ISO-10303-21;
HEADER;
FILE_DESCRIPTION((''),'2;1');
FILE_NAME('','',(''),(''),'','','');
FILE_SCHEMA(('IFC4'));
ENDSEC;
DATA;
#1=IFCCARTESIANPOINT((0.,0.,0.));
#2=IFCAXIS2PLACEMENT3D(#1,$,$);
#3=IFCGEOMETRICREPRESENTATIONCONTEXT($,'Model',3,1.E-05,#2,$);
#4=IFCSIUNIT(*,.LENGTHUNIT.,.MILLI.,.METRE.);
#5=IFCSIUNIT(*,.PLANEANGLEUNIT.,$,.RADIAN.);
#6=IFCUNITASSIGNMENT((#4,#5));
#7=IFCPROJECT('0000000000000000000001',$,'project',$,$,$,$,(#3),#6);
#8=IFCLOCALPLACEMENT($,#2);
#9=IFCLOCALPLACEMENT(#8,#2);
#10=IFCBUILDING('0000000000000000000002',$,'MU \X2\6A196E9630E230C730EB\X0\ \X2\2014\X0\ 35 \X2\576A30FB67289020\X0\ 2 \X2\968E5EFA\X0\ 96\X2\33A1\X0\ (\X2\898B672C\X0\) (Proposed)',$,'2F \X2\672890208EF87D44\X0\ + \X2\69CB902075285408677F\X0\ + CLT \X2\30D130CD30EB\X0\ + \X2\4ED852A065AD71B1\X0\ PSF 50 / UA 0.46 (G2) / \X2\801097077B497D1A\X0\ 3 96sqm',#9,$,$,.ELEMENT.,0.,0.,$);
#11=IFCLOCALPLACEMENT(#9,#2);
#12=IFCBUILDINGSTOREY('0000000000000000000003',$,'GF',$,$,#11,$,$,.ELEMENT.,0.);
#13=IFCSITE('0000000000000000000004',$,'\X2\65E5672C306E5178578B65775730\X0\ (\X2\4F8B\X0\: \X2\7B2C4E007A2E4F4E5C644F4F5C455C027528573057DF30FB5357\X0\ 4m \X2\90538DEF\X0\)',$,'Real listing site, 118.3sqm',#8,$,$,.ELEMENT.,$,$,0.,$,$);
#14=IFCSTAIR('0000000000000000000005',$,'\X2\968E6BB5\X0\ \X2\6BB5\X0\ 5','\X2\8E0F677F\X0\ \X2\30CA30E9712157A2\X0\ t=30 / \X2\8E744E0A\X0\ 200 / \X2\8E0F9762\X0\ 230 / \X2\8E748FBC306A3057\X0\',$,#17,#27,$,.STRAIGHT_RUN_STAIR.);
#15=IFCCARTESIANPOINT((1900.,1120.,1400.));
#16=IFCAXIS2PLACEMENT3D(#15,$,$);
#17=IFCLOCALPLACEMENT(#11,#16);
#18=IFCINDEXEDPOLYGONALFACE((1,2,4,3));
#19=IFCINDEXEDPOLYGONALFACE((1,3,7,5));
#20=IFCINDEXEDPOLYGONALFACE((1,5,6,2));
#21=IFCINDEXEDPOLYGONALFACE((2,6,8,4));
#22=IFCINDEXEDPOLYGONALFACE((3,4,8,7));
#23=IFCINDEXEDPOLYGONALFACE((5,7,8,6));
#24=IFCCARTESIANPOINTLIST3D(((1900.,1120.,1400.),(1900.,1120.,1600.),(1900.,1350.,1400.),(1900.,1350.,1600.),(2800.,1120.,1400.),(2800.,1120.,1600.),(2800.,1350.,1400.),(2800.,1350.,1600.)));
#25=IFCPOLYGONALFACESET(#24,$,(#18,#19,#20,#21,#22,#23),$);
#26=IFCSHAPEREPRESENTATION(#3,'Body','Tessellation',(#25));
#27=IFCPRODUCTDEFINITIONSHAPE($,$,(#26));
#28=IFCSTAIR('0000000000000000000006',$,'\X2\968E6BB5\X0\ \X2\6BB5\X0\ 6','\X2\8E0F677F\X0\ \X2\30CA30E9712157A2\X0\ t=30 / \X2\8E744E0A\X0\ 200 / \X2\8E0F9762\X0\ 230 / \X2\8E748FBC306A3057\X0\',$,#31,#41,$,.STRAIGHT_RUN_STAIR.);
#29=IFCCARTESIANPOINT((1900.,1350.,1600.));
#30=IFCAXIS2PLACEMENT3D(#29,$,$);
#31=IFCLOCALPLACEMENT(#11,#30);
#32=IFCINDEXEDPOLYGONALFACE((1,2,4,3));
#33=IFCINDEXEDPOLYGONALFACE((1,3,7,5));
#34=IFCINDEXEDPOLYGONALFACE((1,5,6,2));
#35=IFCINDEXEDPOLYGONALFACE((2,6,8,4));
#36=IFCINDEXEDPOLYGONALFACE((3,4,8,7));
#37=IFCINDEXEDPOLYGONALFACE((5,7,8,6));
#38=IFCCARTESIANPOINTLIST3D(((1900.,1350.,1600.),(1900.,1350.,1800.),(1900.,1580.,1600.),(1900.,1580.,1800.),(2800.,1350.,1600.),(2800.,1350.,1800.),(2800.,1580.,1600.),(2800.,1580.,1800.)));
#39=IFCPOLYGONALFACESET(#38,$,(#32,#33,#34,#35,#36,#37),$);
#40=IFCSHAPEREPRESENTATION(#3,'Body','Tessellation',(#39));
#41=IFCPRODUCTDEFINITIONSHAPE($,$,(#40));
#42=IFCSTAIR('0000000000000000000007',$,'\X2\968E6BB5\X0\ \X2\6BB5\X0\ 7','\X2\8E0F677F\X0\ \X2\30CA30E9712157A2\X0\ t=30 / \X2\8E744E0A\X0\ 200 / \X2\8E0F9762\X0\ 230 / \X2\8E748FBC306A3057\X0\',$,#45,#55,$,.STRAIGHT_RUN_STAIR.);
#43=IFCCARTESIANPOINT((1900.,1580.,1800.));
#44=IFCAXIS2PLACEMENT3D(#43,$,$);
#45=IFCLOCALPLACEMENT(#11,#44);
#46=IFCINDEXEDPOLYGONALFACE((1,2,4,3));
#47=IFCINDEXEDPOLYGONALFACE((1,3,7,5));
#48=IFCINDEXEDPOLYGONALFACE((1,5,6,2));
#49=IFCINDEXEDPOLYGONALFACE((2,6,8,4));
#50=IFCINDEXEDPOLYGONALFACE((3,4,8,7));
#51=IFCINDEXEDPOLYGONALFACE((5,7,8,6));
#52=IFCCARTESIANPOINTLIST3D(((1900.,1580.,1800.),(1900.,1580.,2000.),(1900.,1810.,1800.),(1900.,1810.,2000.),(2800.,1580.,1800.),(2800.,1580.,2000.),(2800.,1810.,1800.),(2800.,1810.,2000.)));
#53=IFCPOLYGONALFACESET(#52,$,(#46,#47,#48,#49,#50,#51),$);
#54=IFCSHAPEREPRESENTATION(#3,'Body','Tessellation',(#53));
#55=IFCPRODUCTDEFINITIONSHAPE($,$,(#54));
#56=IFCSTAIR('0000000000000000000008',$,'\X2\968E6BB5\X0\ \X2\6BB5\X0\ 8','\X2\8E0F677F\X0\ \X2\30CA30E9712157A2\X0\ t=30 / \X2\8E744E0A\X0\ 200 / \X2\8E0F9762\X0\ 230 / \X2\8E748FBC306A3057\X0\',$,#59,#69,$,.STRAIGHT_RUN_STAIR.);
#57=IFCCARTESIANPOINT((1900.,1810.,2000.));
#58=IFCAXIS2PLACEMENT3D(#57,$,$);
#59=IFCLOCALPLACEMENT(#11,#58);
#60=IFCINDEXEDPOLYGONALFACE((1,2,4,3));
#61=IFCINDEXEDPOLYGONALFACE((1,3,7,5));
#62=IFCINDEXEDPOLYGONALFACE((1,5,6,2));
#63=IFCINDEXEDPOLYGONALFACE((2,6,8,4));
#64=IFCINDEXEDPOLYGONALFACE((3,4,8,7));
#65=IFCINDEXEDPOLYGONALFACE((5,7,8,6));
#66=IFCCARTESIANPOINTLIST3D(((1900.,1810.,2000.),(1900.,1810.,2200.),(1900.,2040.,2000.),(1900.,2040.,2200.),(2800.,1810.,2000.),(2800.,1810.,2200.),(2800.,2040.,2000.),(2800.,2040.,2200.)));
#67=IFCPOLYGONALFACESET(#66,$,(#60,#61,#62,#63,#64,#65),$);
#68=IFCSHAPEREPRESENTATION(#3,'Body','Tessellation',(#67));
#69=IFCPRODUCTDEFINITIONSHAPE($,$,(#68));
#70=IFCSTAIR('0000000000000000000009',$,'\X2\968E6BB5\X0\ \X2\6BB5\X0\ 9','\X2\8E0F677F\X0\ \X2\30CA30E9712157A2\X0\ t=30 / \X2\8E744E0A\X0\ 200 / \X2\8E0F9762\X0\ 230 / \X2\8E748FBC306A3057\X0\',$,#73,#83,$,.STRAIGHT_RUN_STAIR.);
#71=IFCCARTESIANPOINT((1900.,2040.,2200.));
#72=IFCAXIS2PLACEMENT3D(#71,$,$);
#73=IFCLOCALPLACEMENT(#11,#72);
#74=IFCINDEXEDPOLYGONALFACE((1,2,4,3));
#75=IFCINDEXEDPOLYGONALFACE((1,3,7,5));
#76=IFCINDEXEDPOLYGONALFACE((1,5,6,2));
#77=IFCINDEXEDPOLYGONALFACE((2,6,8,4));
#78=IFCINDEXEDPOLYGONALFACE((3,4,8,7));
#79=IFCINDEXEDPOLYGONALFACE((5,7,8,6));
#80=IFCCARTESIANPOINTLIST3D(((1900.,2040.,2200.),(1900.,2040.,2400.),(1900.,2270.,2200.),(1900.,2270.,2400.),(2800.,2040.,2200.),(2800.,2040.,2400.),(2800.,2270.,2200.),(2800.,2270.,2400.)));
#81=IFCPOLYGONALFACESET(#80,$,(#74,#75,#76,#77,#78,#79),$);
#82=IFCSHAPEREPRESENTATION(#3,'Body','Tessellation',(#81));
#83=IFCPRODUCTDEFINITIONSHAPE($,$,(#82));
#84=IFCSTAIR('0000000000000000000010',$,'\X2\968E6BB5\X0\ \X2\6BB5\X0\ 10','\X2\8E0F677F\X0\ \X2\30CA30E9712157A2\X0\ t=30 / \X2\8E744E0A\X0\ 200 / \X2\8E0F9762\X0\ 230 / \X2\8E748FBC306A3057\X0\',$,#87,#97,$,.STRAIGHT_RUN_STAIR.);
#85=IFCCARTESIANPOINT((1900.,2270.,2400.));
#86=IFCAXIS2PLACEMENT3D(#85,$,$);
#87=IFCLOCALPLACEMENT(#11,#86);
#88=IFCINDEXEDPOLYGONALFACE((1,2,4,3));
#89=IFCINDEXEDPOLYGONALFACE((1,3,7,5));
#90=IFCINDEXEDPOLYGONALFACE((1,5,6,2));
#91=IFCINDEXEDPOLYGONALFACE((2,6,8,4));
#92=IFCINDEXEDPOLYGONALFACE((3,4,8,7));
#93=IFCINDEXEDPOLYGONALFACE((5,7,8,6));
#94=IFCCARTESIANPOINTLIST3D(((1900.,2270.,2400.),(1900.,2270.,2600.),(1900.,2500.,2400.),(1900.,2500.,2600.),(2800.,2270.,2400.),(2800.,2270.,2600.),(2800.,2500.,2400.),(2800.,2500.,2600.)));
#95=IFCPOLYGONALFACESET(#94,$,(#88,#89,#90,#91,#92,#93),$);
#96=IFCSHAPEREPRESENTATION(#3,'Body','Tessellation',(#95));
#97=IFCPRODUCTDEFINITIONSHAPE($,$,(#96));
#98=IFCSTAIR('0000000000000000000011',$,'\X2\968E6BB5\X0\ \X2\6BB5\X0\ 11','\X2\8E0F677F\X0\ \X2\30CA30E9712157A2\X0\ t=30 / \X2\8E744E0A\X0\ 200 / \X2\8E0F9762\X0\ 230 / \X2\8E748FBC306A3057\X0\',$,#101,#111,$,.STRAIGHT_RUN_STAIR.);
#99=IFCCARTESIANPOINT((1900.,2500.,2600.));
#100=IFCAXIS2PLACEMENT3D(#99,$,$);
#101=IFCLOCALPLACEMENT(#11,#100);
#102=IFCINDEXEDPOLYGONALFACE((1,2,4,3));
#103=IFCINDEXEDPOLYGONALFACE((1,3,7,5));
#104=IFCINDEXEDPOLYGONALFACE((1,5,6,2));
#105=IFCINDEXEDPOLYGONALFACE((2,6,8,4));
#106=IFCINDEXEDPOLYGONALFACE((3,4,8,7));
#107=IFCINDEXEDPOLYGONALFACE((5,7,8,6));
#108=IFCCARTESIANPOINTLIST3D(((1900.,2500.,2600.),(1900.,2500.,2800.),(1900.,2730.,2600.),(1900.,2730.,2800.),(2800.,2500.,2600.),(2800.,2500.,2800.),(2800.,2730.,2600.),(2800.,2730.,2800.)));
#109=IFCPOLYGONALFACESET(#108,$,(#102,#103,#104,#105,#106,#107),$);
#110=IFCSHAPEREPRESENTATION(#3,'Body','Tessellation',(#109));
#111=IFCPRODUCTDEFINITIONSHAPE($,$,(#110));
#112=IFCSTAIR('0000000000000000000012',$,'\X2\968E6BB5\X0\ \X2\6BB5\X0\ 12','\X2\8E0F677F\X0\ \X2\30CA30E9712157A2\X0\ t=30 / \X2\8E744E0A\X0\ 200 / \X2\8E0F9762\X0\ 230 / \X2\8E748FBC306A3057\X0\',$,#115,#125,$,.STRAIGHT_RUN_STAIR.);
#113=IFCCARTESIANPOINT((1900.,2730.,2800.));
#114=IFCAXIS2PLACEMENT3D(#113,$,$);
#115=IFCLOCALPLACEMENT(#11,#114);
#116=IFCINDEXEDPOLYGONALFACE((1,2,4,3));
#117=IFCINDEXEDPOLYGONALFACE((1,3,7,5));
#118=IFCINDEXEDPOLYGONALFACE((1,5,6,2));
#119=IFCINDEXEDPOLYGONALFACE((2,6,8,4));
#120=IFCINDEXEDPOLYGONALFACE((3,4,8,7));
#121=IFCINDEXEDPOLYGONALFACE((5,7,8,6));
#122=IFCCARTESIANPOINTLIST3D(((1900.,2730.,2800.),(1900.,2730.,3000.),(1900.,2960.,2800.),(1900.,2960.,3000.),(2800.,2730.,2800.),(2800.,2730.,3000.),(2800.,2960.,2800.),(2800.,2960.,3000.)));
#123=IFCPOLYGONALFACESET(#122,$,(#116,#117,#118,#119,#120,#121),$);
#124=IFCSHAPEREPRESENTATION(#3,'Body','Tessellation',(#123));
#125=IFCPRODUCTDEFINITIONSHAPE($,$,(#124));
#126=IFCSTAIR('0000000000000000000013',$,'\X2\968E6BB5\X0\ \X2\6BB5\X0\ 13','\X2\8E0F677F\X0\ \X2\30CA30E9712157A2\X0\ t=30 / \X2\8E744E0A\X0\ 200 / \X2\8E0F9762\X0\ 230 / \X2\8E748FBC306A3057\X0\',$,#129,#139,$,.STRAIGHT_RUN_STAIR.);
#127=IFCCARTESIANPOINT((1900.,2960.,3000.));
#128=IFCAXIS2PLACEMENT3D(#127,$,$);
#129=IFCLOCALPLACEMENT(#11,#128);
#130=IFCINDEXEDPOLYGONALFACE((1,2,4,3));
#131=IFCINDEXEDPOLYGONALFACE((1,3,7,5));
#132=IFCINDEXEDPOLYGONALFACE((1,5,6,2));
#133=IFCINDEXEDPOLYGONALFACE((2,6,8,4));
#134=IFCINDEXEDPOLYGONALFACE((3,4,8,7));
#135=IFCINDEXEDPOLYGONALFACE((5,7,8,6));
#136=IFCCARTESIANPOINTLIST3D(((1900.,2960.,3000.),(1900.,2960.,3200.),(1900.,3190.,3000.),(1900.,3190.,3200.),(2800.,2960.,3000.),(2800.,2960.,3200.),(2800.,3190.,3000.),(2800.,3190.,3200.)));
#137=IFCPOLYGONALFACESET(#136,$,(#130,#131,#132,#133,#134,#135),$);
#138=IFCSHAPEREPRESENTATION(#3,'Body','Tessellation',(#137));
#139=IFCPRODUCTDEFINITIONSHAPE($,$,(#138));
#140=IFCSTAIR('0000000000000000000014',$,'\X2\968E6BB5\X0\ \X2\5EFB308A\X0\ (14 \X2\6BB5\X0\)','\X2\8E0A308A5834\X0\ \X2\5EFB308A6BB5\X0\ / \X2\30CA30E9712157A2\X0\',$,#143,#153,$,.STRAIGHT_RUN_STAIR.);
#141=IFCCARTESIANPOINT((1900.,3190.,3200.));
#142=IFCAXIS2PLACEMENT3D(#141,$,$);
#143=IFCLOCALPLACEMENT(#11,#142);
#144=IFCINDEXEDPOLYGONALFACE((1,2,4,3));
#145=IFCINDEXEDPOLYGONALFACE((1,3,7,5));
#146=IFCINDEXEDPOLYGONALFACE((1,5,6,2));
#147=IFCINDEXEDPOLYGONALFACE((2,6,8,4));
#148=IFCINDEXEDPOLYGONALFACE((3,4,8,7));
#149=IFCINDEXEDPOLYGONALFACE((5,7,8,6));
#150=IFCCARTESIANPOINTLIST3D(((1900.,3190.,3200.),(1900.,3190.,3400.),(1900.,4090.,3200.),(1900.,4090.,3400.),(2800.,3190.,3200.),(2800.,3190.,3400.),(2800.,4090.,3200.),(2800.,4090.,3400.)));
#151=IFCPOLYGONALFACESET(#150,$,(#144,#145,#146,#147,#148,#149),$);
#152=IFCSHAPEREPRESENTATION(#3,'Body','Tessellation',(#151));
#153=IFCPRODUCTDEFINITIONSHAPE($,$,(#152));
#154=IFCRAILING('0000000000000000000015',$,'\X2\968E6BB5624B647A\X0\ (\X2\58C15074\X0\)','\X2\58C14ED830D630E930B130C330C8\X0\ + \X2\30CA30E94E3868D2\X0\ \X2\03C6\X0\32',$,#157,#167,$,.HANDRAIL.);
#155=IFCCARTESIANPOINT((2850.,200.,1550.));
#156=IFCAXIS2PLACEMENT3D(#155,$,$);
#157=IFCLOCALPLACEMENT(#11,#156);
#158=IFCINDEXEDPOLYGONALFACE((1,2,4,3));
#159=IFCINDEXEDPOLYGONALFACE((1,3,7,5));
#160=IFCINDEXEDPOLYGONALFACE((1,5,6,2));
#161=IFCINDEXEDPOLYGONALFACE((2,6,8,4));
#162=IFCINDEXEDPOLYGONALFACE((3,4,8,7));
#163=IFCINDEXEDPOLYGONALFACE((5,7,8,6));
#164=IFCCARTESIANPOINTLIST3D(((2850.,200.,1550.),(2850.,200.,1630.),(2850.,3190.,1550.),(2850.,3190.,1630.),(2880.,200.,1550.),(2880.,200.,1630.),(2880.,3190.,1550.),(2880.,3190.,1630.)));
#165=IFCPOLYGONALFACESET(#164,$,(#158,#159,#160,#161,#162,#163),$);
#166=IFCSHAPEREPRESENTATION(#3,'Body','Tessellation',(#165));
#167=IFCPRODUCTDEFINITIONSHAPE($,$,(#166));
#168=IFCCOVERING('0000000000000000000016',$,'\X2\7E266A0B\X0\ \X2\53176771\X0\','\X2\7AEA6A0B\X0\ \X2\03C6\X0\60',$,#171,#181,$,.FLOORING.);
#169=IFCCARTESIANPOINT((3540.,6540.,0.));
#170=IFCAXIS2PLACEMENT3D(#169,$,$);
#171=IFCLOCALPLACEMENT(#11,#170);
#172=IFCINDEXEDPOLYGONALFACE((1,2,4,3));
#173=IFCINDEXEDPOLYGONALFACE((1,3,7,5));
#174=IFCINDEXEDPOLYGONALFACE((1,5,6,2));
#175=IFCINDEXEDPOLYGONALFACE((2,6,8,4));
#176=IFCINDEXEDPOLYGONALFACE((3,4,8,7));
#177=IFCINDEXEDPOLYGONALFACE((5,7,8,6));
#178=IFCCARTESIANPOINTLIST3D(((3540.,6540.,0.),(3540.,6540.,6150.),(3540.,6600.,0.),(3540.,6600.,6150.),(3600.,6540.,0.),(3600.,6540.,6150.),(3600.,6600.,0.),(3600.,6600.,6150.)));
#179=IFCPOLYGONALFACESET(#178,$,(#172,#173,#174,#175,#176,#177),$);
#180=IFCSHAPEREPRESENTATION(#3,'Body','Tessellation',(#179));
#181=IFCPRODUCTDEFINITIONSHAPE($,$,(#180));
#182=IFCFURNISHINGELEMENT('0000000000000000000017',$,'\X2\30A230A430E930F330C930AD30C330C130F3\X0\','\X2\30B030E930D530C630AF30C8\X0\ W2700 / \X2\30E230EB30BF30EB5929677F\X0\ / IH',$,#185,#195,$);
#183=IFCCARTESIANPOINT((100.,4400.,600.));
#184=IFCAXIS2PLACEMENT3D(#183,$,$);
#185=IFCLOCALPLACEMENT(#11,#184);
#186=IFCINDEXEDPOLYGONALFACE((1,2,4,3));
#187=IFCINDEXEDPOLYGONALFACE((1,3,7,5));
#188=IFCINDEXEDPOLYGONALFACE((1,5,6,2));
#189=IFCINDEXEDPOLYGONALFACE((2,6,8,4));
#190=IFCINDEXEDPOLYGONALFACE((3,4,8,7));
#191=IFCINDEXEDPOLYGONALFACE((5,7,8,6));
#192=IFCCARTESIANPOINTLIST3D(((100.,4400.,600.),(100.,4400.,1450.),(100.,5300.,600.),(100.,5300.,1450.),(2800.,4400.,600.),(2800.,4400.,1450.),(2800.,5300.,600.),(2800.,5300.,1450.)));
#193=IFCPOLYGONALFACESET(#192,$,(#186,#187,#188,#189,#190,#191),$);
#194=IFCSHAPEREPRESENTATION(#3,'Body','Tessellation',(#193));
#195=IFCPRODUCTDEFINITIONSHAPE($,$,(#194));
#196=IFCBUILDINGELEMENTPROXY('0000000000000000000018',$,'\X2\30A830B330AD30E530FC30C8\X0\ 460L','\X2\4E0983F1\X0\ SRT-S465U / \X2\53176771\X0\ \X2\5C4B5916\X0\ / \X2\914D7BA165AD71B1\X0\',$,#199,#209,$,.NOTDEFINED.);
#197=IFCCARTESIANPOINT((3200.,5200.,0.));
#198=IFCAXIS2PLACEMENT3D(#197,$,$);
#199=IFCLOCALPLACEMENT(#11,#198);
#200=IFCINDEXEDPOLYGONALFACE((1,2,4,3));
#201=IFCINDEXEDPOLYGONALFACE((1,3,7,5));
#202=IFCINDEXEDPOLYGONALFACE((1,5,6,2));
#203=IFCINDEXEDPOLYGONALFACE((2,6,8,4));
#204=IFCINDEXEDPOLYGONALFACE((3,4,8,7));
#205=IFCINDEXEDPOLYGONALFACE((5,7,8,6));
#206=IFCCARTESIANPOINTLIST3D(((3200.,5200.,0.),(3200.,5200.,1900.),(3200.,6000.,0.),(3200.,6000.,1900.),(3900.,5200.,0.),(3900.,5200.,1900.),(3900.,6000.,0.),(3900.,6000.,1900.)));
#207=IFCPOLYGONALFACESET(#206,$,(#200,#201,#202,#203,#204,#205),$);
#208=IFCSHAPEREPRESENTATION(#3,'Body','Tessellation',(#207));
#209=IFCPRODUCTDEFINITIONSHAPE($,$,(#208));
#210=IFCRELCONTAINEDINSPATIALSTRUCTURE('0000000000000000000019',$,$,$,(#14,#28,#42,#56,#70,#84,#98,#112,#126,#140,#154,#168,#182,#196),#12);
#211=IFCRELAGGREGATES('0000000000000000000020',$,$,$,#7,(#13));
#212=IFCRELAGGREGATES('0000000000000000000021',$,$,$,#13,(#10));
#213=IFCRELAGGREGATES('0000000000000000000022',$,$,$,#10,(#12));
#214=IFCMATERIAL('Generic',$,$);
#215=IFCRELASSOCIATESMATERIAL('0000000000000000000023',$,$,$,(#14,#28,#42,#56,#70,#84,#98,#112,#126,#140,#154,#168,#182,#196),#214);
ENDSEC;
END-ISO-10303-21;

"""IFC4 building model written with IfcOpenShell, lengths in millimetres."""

from ifc_helpers import new_model, si_unit, frame, frame_2d, origin, place, context, project, spatial, rectangle, extrude, material, element, save


model = new_model("IFC4")

# Units and contexts
model_context = context("Model", 3, precision=1e-05, world=origin())
ifc_project = project(units=[si_unit("LENGTHUNIT", "METRE", prefix="MILLI"), si_unit("PLANEANGLEUNIT", "RADIAN")], contexts=[model_context])

# Site, building, storey
site_placement = place(None, origin())
site = spatial("IfcSite", under=ifc_project, at=site_placement, Name="日本の典型敷地 (例: 第一種低層住居専用地域・南 4m 道路)", ObjectType="Real listing site, 118.3sqm", CompositionType="ELEMENT", RefElevation=0.0)
building_placement = place(site_placement, origin())
building = spatial("IfcBuilding", under=site, at=building_placement, Name="MU 標準モデル — 35 坪・木造 2 階建 96㎡ (見本) (Proposed)", ObjectType="2F 木造軸組 + 構造用合板 + CLT パネル + 付加断熱 PSF 50 / UA 0.46 (G2) / 耐震等級 3 96sqm", CompositionType="ELEMENT", ElevationOfRefHeight=0.0, ElevationOfTerrain=0.0)
storey_placement = place(building_placement, origin())
storey = spatial("IfcBuildingStorey", under=building, at=storey_placement, Name="GF", CompositionType="ELEMENT", Elevation=0.0)

# Shared definitions
ifc_material_1 = material(Name="Generic")

# Stairs
stair_1_placement = place(storey_placement, frame((1900.0, 1120.0, 1400.0)))
element("IfcStair", 1, at=stair_1_placement, inside=storey, material=ifc_material_1, Name="階段 段 5", Description="踏板 ナラ無垢 t=30 / 蹴上 200 / 踏面 230 / 蹴込なし", PredefinedType="STRAIGHT_RUN_STAIR", context=model_context, shape_type="SweptSolid", body=[
    extrude(rectangle(XDim=900.0, YDim=230.0, at=frame_2d((450.0, 115.0))), frame((1900.0, 1120.0, 1400.0)), (0.0, 0.0, 1.0), 200.0),
])
stair_2_placement = place(storey_placement, frame((1900.0, 1350.0, 1600.0)))
element("IfcStair", 2, at=stair_2_placement, inside=storey, material=ifc_material_1, Name="階段 段 6", Description="踏板 ナラ無垢 t=30 / 蹴上 200 / 踏面 230 / 蹴込なし", PredefinedType="STRAIGHT_RUN_STAIR", context=model_context, shape_type="SweptSolid", body=[
    extrude(rectangle(XDim=900.0, YDim=230.0, at=frame_2d((450.0, 115.0))), frame((1900.0, 1350.0, 1600.0)), (0.0, 0.0, 1.0), 200.0),
])
stair_3_placement = place(storey_placement, frame((1900.0, 1580.0, 1800.0)))
element("IfcStair", 3, at=stair_3_placement, inside=storey, material=ifc_material_1, Name="階段 段 7", Description="踏板 ナラ無垢 t=30 / 蹴上 200 / 踏面 230 / 蹴込なし", PredefinedType="STRAIGHT_RUN_STAIR", context=model_context, shape_type="SweptSolid", body=[
    extrude(rectangle(XDim=900.0, YDim=230.0, at=frame_2d((450.0, 115.0))), frame((1900.0, 1580.0, 1800.0)), (0.0, 0.0, 1.0), 200.0),
])
stair_4_placement = place(storey_placement, frame((1900.0, 1810.0, 2000.0)))
element("IfcStair", 4, at=stair_4_placement, inside=storey, material=ifc_material_1, Name="階段 段 8", Description="踏板 ナラ無垢 t=30 / 蹴上 200 / 踏面 230 / 蹴込なし", PredefinedType="STRAIGHT_RUN_STAIR", context=model_context, shape_type="SweptSolid", body=[
    extrude(rectangle(XDim=900.0, YDim=230.0, at=frame_2d((450.0, 115.0))), frame((1900.0, 1810.0, 2000.0)), (0.0, 0.0, 1.0), 200.0),
])
stair_5_placement = place(storey_placement, frame((1900.0, 2040.0, 2200.0)))
element("IfcStair", 5, at=stair_5_placement, inside=storey, material=ifc_material_1, Name="階段 段 9", Description="踏板 ナラ無垢 t=30 / 蹴上 200 / 踏面 230 / 蹴込なし", PredefinedType="STRAIGHT_RUN_STAIR", context=model_context, shape_type="SweptSolid", body=[
    extrude(rectangle(XDim=900.0, YDim=230.0, at=frame_2d((450.0, 115.0))), frame((1900.0, 2040.0, 2200.0)), (0.0, 0.0, 1.0), 200.0),
])
stair_6_placement = place(storey_placement, frame((1900.0, 2270.0, 2400.0)))
element("IfcStair", 6, at=stair_6_placement, inside=storey, material=ifc_material_1, Name="階段 段 10", Description="踏板 ナラ無垢 t=30 / 蹴上 200 / 踏面 230 / 蹴込なし", PredefinedType="STRAIGHT_RUN_STAIR", context=model_context, shape_type="SweptSolid", body=[
    extrude(rectangle(XDim=900.0, YDim=230.0, at=frame_2d((450.0, 115.0))), frame((1900.0, 2270.0, 2400.0)), (0.0, 0.0, 1.0), 200.0),
])
stair_7_placement = place(storey_placement, frame((1900.0, 2500.0, 2600.0)))
element("IfcStair", 7, at=stair_7_placement, inside=storey, material=ifc_material_1, Name="階段 段 11", Description="踏板 ナラ無垢 t=30 / 蹴上 200 / 踏面 230 / 蹴込なし", PredefinedType="STRAIGHT_RUN_STAIR", context=model_context, shape_type="SweptSolid", body=[
    extrude(rectangle(XDim=900.0, YDim=230.0, at=frame_2d((450.0, 115.0))), frame((1900.0, 2500.0, 2600.0)), (0.0, 0.0, 1.0), 200.0),
])
stair_8_placement = place(storey_placement, frame((1900.0, 2730.0, 2800.0)))
element("IfcStair", 8, at=stair_8_placement, inside=storey, material=ifc_material_1, Name="階段 段 12", Description="踏板 ナラ無垢 t=30 / 蹴上 200 / 踏面 230 / 蹴込なし", PredefinedType="STRAIGHT_RUN_STAIR", context=model_context, shape_type="SweptSolid", body=[
    extrude(rectangle(XDim=900.0, YDim=230.0, at=frame_2d((450.0, 115.0))), frame((1900.0, 2730.0, 2800.0)), (0.0, 0.0, 1.0), 200.0),
])
stair_9_placement = place(storey_placement, frame((1900.0, 2960.0, 3000.0)))
element("IfcStair", 9, at=stair_9_placement, inside=storey, material=ifc_material_1, Name="階段 段 13", Description="踏板 ナラ無垢 t=30 / 蹴上 200 / 踏面 230 / 蹴込なし", PredefinedType="STRAIGHT_RUN_STAIR", context=model_context, shape_type="SweptSolid", body=[
    extrude(rectangle(XDim=900.0, YDim=230.0, at=frame_2d((450.0, 115.0))), frame((1900.0, 2960.0, 3000.0)), (0.0, 0.0, 1.0), 200.0),
])
stair_10_placement = place(storey_placement, frame((1900.0, 3190.0, 3200.0)))
element("IfcStair", 10, at=stair_10_placement, inside=storey, material=ifc_material_1, Name="階段 廻り (14 段)", Description="踊り場 廻り段 / ナラ無垢", PredefinedType="STRAIGHT_RUN_STAIR", context=model_context, shape_type="SweptSolid", body=[
    extrude(rectangle(XDim=900.0, YDim=900.0, at=frame_2d((450.0, 450.0))), frame((1900.0, 3190.0, 3200.0)), (0.0, 0.0, 1.0), 200.0),
])

# Railing
railing_placement = place(storey_placement, frame((2850.0, 200.0, 1550.0)))
element("IfcRailing", 11, at=railing_placement, inside=storey, material=ifc_material_1, Name="階段手摺 (壁側)", Description="壁付ブラケット + ナラ丸棒 φ32", PredefinedType="HANDRAIL", context=model_context, shape_type="SweptSolid", body=[
    extrude(rectangle(XDim=30.0, YDim=2990.0, at=frame_2d((15.0, 1495.0))), frame((2850.0, 200.0, 1550.0)), (0.0, 0.0, 1.0), 80.0),
])

# Covering
covering_placement = place(storey_placement, frame((3540.0, 6540.0, 0.0)))
element("IfcCovering", 12, at=covering_placement, inside=storey, material=ifc_material_1, Name="縦樋 北東", Description="竪樋 φ60", PredefinedType="FLOORING", context=model_context, shape_type="SweptSolid", body=[
    extrude(rectangle(XDim=60.0, YDim=60.0, at=frame_2d((30.0, 30.0))), frame((3540.0, 6540.0, 0.0)), (0.0, 0.0, 1.0), 6150.0),
])

# Furnishing element
furnishing_placement = place(storey_placement, frame((100.0, 4400.0, 600.0)))
element("IfcFurnishingElement", 13, at=furnishing_placement, inside=storey, material=ifc_material_1, Name="アイランドキッチン", Description="グラフテクト W2700 / モルタル天板 / IH", context=model_context, shape_type="SweptSolid", body=[
    extrude(rectangle(XDim=2700.0, YDim=900.0, at=frame_2d((1350.0, 450.0))), frame((100.0, 4400.0, 600.0)), (0.0, 0.0, 1.0), 850.0),
])

# Building element proxy
proxy_1_placement = place(storey_placement, frame((3200.0, 5200.0, 0.0)))
element("IfcBuildingElementProxy", 14, at=proxy_1_placement, inside=storey, material=ifc_material_1, Name="エコキュート 460L", Description="三菱 SRT-S465U / 北東 屋外 / 配管断熱", PredefinedType="NOTDEFINED", context=model_context, shape_type="SweptSolid", body=[
    extrude(rectangle(XDim=700.0, YDim=800.0, at=frame_2d((350.0, 400.0))), frame((3200.0, 5200.0, 0.0)), (0.0, 0.0, 1.0), 1900.0),
])

save(model, "model.ifc")
